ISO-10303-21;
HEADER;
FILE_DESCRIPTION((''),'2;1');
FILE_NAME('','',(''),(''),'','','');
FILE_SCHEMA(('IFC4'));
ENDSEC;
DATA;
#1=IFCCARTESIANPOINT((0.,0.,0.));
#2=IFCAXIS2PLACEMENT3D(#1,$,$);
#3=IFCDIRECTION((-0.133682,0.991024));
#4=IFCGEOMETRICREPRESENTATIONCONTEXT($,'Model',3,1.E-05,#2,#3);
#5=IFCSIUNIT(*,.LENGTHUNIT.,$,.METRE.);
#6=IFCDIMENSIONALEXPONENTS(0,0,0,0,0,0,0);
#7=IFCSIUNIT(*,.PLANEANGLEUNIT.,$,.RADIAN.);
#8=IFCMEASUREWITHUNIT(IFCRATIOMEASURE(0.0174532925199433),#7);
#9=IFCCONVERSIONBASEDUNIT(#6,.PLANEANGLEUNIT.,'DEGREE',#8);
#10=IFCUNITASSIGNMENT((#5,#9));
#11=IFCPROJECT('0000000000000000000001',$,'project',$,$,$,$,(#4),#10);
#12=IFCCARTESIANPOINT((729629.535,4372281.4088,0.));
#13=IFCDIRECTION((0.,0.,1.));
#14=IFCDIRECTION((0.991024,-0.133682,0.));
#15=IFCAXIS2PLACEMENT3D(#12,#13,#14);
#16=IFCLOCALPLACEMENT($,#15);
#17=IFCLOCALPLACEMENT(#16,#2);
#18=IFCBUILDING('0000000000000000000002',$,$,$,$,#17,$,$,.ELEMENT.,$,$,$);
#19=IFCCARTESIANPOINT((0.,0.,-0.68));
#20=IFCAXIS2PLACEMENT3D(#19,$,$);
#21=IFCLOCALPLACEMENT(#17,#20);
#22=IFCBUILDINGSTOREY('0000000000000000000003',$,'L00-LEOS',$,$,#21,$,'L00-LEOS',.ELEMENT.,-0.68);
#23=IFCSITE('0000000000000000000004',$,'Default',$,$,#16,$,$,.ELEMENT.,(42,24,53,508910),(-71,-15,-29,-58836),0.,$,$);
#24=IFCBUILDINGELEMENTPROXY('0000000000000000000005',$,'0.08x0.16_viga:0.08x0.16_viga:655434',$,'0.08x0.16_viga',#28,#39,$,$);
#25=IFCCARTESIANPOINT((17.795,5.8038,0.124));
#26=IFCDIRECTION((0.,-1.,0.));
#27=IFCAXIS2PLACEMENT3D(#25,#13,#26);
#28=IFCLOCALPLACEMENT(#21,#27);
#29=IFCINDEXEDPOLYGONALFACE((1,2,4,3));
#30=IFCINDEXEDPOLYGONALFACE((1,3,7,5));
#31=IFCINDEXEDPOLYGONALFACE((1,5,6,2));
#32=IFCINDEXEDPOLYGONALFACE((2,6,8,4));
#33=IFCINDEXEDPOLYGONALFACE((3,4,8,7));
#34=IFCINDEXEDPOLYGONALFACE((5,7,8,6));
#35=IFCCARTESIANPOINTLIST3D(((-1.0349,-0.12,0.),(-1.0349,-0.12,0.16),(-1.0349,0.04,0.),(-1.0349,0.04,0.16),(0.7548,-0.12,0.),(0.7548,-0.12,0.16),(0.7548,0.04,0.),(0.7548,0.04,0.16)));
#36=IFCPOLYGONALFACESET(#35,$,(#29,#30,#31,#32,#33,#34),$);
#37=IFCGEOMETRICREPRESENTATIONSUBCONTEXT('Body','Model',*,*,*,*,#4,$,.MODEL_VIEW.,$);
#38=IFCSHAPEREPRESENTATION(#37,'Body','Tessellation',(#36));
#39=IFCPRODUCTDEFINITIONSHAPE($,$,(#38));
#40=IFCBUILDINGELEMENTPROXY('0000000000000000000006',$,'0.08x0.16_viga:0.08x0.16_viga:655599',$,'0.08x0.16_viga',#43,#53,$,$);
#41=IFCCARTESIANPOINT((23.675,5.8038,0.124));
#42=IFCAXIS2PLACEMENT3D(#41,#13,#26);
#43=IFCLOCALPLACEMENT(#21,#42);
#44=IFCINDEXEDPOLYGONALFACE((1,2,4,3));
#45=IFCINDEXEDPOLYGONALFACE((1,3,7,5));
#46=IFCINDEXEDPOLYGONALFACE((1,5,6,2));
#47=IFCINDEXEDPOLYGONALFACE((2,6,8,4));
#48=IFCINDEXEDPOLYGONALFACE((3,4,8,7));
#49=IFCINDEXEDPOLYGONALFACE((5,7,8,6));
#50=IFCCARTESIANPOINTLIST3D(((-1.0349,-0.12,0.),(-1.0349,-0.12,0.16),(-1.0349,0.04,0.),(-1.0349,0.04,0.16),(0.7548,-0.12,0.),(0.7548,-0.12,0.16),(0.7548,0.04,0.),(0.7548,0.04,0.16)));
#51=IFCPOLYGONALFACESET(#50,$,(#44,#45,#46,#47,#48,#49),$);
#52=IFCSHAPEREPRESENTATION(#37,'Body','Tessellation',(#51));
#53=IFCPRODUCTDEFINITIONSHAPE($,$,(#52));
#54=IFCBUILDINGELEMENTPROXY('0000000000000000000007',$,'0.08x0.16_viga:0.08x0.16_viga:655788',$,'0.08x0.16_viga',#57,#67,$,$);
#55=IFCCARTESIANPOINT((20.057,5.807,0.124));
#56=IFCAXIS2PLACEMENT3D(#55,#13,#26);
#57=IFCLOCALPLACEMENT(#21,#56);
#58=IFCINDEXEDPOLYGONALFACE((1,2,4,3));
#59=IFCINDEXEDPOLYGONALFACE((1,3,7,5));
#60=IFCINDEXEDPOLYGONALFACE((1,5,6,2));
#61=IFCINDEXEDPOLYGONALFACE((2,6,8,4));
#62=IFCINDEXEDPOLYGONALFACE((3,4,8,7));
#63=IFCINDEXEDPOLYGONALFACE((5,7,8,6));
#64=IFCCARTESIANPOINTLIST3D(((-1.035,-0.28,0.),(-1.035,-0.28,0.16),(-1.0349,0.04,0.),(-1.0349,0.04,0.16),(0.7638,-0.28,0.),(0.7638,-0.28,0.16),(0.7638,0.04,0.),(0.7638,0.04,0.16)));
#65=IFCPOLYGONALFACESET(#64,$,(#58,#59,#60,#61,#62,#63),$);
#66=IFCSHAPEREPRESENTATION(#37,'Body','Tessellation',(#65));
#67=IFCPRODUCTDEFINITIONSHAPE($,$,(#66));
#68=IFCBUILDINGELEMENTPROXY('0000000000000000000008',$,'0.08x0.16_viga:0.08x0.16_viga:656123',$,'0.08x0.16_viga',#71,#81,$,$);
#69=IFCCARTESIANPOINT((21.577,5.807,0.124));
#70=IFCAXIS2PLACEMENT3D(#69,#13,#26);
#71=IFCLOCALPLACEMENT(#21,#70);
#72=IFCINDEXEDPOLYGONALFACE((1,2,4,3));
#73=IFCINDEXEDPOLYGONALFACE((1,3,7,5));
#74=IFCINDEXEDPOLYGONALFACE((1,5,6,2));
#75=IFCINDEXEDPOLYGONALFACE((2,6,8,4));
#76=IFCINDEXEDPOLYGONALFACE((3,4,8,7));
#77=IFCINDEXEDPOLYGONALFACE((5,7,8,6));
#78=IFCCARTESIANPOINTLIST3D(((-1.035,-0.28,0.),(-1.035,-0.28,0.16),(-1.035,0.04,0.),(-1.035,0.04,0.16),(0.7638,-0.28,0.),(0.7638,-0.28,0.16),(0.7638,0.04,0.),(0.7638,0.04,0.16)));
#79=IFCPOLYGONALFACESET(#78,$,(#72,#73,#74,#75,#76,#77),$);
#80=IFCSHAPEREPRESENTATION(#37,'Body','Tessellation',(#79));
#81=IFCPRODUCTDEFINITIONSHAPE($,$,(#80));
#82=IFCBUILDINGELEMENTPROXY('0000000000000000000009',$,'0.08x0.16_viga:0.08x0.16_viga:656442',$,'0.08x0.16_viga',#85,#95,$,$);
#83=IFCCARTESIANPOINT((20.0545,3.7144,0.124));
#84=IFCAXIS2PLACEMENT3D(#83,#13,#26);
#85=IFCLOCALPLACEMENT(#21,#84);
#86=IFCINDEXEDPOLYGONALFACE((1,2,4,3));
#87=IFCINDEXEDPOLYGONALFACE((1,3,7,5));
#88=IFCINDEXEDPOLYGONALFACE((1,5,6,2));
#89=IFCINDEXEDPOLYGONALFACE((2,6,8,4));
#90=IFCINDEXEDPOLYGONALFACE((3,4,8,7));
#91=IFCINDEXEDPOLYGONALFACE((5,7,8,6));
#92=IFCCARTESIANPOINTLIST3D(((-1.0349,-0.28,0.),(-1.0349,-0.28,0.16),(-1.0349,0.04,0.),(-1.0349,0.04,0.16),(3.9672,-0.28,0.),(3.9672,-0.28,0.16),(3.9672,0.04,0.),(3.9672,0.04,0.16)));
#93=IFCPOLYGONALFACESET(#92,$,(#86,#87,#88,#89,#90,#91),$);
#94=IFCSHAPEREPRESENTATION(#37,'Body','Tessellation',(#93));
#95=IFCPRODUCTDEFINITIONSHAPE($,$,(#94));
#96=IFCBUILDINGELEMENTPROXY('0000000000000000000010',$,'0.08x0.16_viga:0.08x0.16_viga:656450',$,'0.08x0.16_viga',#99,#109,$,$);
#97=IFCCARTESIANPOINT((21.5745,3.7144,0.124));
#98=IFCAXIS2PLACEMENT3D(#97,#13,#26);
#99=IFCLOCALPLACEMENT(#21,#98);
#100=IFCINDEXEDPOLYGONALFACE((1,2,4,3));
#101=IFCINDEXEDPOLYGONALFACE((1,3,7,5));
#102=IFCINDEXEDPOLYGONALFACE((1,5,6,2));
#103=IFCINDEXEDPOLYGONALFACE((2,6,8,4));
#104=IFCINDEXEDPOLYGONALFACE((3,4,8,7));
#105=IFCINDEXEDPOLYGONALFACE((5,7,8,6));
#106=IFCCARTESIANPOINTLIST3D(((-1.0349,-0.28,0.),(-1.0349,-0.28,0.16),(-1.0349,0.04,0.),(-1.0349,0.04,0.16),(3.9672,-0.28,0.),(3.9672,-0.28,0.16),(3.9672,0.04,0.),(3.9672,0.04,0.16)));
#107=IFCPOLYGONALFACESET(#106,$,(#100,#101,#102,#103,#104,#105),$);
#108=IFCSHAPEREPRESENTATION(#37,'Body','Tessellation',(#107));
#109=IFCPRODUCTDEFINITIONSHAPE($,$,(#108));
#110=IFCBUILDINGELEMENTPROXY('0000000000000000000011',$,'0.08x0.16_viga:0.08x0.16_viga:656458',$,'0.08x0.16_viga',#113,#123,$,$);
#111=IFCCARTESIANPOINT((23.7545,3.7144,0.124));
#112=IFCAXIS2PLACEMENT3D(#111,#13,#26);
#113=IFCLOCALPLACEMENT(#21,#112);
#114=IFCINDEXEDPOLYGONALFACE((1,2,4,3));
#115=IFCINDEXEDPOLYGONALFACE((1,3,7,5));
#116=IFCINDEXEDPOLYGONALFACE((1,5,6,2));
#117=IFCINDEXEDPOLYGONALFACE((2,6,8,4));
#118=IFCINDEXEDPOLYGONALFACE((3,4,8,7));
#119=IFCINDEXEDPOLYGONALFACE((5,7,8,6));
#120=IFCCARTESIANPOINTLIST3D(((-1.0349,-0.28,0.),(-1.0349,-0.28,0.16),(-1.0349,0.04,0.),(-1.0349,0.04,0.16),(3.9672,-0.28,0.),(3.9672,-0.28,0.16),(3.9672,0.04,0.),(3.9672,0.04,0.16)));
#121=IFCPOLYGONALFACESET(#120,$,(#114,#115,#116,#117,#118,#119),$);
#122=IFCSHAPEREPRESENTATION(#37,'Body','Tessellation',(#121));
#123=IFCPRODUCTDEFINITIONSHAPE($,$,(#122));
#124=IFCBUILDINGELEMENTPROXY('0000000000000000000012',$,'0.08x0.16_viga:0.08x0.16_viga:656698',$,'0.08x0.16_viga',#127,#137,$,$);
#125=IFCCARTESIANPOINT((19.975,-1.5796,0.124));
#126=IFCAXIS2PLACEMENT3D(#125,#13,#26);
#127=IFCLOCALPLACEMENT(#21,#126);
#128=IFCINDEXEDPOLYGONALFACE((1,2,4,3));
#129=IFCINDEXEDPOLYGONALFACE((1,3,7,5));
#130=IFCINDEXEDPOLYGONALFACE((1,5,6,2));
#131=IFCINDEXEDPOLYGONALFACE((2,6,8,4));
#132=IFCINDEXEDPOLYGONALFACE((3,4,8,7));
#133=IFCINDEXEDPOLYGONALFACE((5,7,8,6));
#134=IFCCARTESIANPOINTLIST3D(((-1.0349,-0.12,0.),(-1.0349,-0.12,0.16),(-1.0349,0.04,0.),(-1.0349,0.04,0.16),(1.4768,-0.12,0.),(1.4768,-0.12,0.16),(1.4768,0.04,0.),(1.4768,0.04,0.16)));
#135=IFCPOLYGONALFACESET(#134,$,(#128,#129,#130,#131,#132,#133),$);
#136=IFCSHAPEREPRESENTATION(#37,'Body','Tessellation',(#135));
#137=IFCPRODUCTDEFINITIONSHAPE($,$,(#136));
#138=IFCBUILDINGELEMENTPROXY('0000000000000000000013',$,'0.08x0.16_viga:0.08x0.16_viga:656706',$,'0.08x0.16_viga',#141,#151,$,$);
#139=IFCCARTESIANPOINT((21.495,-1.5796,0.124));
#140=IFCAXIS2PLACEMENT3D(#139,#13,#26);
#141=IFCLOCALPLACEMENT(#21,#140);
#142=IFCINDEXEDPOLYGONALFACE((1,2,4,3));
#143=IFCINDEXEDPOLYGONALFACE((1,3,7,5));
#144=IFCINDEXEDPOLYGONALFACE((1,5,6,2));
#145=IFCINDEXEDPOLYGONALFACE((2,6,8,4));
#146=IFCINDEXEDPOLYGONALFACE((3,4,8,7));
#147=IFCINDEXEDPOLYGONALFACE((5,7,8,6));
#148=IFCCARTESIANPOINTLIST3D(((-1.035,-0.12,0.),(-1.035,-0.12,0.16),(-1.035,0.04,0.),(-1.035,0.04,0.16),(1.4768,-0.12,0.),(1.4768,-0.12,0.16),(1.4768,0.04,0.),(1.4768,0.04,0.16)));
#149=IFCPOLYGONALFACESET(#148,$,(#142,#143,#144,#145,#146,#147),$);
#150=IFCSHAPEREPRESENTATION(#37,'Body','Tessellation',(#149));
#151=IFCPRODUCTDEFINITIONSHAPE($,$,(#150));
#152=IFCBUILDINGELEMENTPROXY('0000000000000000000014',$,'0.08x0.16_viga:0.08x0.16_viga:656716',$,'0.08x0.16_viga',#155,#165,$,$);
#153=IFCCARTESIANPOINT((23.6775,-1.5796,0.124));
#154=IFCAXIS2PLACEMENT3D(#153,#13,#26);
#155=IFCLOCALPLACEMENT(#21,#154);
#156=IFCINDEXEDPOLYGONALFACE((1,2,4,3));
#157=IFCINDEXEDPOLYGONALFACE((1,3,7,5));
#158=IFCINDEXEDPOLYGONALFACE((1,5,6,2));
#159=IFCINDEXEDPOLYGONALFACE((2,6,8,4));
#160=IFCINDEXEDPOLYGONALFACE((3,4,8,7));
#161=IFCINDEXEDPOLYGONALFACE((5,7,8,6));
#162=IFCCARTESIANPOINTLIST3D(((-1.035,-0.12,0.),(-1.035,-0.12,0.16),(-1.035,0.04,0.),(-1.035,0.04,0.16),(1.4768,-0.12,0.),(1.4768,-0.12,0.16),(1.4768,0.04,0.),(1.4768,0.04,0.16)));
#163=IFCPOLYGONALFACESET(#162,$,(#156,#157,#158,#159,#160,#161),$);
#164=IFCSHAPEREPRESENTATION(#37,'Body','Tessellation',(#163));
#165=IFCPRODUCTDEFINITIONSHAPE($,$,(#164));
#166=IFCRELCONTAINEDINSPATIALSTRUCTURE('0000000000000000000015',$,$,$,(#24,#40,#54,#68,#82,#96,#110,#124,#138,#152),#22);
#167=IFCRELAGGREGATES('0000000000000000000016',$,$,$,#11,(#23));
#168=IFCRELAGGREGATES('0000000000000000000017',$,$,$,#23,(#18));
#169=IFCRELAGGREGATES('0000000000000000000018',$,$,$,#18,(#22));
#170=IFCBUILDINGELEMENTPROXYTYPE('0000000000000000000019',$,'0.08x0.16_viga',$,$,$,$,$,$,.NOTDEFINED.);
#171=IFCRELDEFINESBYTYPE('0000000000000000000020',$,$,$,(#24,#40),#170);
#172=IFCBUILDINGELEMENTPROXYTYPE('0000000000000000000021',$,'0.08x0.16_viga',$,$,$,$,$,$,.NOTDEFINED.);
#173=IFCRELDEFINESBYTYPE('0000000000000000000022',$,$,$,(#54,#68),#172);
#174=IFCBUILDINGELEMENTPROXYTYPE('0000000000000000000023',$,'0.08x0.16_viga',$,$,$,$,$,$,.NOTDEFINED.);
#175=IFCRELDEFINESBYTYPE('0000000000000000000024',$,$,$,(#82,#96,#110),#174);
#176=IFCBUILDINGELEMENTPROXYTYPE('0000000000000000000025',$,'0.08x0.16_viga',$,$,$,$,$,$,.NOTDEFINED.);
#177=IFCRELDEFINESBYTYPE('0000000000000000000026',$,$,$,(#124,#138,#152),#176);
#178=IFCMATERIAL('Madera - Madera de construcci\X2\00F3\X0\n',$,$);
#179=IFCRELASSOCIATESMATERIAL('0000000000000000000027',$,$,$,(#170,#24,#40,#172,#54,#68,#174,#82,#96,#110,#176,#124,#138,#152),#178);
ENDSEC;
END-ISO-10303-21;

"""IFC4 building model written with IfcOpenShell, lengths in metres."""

from ifc_helpers import new_model, entity, si_unit, converted_unit, direction, frame, origin, origin_2d_with_axis, place, context, subcontext, project, spatial, rectangle, extrude, source, transform, mapped, material, type_object, type_shapes, element, save


model = new_model("IFC4")

# Units and contexts
model_context = context("Model", 3, precision=1e-05, world=origin(), true_north=direction((-0.133682, 0.991024)))
body_context = subcontext(model_context, "Body", "Model", "MODEL_VIEW")
ifc_project = project(units=[si_unit("LENGTHUNIT", "METRE"), converted_unit("PLANEANGLEUNIT", "DEGREE", entity("IfcRatioMeasure", 0.0174532925199433), si_unit("PLANEANGLEUNIT", "RADIAN"), dimensions=[0, 0, 0, 0, 0, 0, 0])], contexts=[model_context])

# Site, building, storey
site_placement = place(None, frame((729629.535, 4372281.4088, 0.0), z_axis=(0.0, 0.0, 1.0), x_axis=(0.991024, -0.133682, 0.0)))
site = spatial("IfcSite", under=ifc_project, at=site_placement, Name="Default", CompositionType="ELEMENT", RefLatitude=(42, 24, 53, 508910), RefLongitude=(-71, -15, -29, -58836), RefElevation=0.0)
building_placement = place(site_placement, origin())
building = spatial("IfcBuilding", under=site, at=building_placement, CompositionType="ELEMENT")
storey_placement = place(building_placement, frame((0.0, 0.0, -0.68)))
storey = spatial("IfcBuildingStorey", under=building, at=storey_placement, Name="L00-LEOS", LongName="L00-LEOS", CompositionType="ELEMENT", Elevation=-0.68)

# Building element proxies
ifc_material = material(Name="Madera - Madera de construcción")
building_element_proxy_type_1 = type_object("IfcBuildingElementProxyType", Name="0.08x0.16_viga", material=ifc_material)
shared_shape_1 = source(origin(), body_context, "Body", "SweptSolid", [
    extrude(rectangle(XDim=0.16, YDim=1.7897, at=origin_2d_with_axis()), frame((-0.1401, -0.04, 0.0), z_axis=(0.0, 0.0, 1.0), x_axis=(0.0, -1.0, 0.0)), (0.0, 0.0, 1.0), 0.16),
])
type_shapes(building_element_proxy_type_1, [shared_shape_1])
for number, where, z_axis, x_axis, name in (
    (1, (17.795, 5.8038, 0.124), (0.0, 0.0, 1.0), (0.0, -1.0, 0.0), "0.08x0.16_viga:0.08x0.16_viga:655434"),
    (2, (23.675, 5.8038, 0.124), (0.0, 0.0, 1.0), (0.0, -1.0, 0.0), "0.08x0.16_viga:0.08x0.16_viga:655599"),
):
    element("IfcBuildingElementProxy", number, at=place(storey_placement, frame(where, z_axis=z_axis, x_axis=x_axis)), inside=storey, type_object=building_element_proxy_type_1, material=ifc_material, Name=name, ObjectType="0.08x0.16_viga", context=body_context, shape_type="MappedRepresentation", body=[
        mapped(shared_shape_1, transform((0.0, 0.0, 0.0), scale=1.0)),
    ])
building_element_proxy_type_2 = type_object("IfcBuildingElementProxyType", Name="0.08x0.16_viga", material=ifc_material)
shared_shape_2 = source(origin(), body_context, "Body", "SweptSolid", [
    extrude(rectangle(XDim=0.32, YDim=1.7988, at=origin_2d_with_axis()), frame((-0.1356, -0.12, 0.0), z_axis=(0.0, 0.0, 1.0), x_axis=(0.0, -1.0, 0.0)), (0.0, 0.0, 1.0), 0.16),
])
type_shapes(building_element_proxy_type_2, [shared_shape_2])
for number, where, z_axis, x_axis, name in (
    (3, (20.057, 5.807, 0.124), (0.0, 0.0, 1.0), (0.0, -1.0, 0.0), "0.08x0.16_viga:0.08x0.16_viga:655788"),
    (4, (21.577, 5.807, 0.124), (0.0, 0.0, 1.0), (0.0, -1.0, 0.0), "0.08x0.16_viga:0.08x0.16_viga:656123"),
):
    element("IfcBuildingElementProxy", number, at=place(storey_placement, frame(where, z_axis=z_axis, x_axis=x_axis)), inside=storey, type_object=building_element_proxy_type_2, material=ifc_material, Name=name, ObjectType="0.08x0.16_viga", context=body_context, shape_type="MappedRepresentation", body=[
        mapped(shared_shape_2, transform((0.0, 0.0, 0.0), scale=1.0)),
    ])
building_element_proxy_type_3 = type_object("IfcBuildingElementProxyType", Name="0.08x0.16_viga", material=ifc_material)
shared_shape_3 = source(origin(), body_context, "Body", "SweptSolid", [
    extrude(rectangle(XDim=0.32, YDim=5.0021, at=origin_2d_with_axis()), frame((1.4661, -0.12, 0.0), z_axis=(0.0, 0.0, 1.0), x_axis=(0.0, -1.0, 0.0)), (0.0, 0.0, 1.0), 0.16),
])
type_shapes(building_element_proxy_type_3, [shared_shape_3])
for number, where, z_axis, x_axis, name in (
    (5, (20.0545, 3.7144, 0.124), (0.0, 0.0, 1.0), (0.0, -1.0, 0.0), "0.08x0.16_viga:0.08x0.16_viga:656442"),
    (6, (21.5745, 3.7144, 0.124), (0.0, 0.0, 1.0), (0.0, -1.0, 0.0), "0.08x0.16_viga:0.08x0.16_viga:656450"),
    (7, (23.7545, 3.7144, 0.124), (0.0, 0.0, 1.0), (0.0, -1.0, 0.0), "0.08x0.16_viga:0.08x0.16_viga:656458"),
):
    element("IfcBuildingElementProxy", number, at=place(storey_placement, frame(where, z_axis=z_axis, x_axis=x_axis)), inside=storey, type_object=building_element_proxy_type_3, material=ifc_material, Name=name, ObjectType="0.08x0.16_viga", context=body_context, shape_type="MappedRepresentation", body=[
        mapped(shared_shape_3, transform((0.0, 0.0, 0.0), scale=1.0)),
    ])
building_element_proxy_type_4 = type_object("IfcBuildingElementProxyType", Name="0.08x0.16_viga", material=ifc_material)
shared_shape_4 = source(origin(), body_context, "Body", "SweptSolid", [
    extrude(rectangle(XDim=0.16, YDim=2.5117, at=origin_2d_with_axis()), frame((0.2209, -0.04, 0.0), z_axis=(0.0, 0.0, 1.0), x_axis=(0.0, -1.0, 0.0)), (0.0, 0.0, 1.0), 0.16),
])
type_shapes(building_element_proxy_type_4, [shared_shape_4])
for number, where, z_axis, x_axis, name in (
    (8, (19.975, -1.5796, 0.124), (0.0, 0.0, 1.0), (0.0, -1.0, 0.0), "0.08x0.16_viga:0.08x0.16_viga:656698"),
    (9, (21.495, -1.5796, 0.124), (0.0, 0.0, 1.0), (0.0, -1.0, 0.0), "0.08x0.16_viga:0.08x0.16_viga:656706"),
    (10, (23.6775, -1.5796, 0.124), (0.0, 0.0, 1.0), (0.0, -1.0, 0.0), "0.08x0.16_viga:0.08x0.16_viga:656716"),
):
    element("IfcBuildingElementProxy", number, at=place(storey_placement, frame(where, z_axis=z_axis, x_axis=x_axis)), inside=storey, type_object=building_element_proxy_type_4, material=ifc_material, Name=name, ObjectType="0.08x0.16_viga", context=body_context, shape_type="MappedRepresentation", body=[
        mapped(shared_shape_4, transform((0.0, 0.0, 0.0), scale=1.0)),
    ])

save(model, "model.ifc")
